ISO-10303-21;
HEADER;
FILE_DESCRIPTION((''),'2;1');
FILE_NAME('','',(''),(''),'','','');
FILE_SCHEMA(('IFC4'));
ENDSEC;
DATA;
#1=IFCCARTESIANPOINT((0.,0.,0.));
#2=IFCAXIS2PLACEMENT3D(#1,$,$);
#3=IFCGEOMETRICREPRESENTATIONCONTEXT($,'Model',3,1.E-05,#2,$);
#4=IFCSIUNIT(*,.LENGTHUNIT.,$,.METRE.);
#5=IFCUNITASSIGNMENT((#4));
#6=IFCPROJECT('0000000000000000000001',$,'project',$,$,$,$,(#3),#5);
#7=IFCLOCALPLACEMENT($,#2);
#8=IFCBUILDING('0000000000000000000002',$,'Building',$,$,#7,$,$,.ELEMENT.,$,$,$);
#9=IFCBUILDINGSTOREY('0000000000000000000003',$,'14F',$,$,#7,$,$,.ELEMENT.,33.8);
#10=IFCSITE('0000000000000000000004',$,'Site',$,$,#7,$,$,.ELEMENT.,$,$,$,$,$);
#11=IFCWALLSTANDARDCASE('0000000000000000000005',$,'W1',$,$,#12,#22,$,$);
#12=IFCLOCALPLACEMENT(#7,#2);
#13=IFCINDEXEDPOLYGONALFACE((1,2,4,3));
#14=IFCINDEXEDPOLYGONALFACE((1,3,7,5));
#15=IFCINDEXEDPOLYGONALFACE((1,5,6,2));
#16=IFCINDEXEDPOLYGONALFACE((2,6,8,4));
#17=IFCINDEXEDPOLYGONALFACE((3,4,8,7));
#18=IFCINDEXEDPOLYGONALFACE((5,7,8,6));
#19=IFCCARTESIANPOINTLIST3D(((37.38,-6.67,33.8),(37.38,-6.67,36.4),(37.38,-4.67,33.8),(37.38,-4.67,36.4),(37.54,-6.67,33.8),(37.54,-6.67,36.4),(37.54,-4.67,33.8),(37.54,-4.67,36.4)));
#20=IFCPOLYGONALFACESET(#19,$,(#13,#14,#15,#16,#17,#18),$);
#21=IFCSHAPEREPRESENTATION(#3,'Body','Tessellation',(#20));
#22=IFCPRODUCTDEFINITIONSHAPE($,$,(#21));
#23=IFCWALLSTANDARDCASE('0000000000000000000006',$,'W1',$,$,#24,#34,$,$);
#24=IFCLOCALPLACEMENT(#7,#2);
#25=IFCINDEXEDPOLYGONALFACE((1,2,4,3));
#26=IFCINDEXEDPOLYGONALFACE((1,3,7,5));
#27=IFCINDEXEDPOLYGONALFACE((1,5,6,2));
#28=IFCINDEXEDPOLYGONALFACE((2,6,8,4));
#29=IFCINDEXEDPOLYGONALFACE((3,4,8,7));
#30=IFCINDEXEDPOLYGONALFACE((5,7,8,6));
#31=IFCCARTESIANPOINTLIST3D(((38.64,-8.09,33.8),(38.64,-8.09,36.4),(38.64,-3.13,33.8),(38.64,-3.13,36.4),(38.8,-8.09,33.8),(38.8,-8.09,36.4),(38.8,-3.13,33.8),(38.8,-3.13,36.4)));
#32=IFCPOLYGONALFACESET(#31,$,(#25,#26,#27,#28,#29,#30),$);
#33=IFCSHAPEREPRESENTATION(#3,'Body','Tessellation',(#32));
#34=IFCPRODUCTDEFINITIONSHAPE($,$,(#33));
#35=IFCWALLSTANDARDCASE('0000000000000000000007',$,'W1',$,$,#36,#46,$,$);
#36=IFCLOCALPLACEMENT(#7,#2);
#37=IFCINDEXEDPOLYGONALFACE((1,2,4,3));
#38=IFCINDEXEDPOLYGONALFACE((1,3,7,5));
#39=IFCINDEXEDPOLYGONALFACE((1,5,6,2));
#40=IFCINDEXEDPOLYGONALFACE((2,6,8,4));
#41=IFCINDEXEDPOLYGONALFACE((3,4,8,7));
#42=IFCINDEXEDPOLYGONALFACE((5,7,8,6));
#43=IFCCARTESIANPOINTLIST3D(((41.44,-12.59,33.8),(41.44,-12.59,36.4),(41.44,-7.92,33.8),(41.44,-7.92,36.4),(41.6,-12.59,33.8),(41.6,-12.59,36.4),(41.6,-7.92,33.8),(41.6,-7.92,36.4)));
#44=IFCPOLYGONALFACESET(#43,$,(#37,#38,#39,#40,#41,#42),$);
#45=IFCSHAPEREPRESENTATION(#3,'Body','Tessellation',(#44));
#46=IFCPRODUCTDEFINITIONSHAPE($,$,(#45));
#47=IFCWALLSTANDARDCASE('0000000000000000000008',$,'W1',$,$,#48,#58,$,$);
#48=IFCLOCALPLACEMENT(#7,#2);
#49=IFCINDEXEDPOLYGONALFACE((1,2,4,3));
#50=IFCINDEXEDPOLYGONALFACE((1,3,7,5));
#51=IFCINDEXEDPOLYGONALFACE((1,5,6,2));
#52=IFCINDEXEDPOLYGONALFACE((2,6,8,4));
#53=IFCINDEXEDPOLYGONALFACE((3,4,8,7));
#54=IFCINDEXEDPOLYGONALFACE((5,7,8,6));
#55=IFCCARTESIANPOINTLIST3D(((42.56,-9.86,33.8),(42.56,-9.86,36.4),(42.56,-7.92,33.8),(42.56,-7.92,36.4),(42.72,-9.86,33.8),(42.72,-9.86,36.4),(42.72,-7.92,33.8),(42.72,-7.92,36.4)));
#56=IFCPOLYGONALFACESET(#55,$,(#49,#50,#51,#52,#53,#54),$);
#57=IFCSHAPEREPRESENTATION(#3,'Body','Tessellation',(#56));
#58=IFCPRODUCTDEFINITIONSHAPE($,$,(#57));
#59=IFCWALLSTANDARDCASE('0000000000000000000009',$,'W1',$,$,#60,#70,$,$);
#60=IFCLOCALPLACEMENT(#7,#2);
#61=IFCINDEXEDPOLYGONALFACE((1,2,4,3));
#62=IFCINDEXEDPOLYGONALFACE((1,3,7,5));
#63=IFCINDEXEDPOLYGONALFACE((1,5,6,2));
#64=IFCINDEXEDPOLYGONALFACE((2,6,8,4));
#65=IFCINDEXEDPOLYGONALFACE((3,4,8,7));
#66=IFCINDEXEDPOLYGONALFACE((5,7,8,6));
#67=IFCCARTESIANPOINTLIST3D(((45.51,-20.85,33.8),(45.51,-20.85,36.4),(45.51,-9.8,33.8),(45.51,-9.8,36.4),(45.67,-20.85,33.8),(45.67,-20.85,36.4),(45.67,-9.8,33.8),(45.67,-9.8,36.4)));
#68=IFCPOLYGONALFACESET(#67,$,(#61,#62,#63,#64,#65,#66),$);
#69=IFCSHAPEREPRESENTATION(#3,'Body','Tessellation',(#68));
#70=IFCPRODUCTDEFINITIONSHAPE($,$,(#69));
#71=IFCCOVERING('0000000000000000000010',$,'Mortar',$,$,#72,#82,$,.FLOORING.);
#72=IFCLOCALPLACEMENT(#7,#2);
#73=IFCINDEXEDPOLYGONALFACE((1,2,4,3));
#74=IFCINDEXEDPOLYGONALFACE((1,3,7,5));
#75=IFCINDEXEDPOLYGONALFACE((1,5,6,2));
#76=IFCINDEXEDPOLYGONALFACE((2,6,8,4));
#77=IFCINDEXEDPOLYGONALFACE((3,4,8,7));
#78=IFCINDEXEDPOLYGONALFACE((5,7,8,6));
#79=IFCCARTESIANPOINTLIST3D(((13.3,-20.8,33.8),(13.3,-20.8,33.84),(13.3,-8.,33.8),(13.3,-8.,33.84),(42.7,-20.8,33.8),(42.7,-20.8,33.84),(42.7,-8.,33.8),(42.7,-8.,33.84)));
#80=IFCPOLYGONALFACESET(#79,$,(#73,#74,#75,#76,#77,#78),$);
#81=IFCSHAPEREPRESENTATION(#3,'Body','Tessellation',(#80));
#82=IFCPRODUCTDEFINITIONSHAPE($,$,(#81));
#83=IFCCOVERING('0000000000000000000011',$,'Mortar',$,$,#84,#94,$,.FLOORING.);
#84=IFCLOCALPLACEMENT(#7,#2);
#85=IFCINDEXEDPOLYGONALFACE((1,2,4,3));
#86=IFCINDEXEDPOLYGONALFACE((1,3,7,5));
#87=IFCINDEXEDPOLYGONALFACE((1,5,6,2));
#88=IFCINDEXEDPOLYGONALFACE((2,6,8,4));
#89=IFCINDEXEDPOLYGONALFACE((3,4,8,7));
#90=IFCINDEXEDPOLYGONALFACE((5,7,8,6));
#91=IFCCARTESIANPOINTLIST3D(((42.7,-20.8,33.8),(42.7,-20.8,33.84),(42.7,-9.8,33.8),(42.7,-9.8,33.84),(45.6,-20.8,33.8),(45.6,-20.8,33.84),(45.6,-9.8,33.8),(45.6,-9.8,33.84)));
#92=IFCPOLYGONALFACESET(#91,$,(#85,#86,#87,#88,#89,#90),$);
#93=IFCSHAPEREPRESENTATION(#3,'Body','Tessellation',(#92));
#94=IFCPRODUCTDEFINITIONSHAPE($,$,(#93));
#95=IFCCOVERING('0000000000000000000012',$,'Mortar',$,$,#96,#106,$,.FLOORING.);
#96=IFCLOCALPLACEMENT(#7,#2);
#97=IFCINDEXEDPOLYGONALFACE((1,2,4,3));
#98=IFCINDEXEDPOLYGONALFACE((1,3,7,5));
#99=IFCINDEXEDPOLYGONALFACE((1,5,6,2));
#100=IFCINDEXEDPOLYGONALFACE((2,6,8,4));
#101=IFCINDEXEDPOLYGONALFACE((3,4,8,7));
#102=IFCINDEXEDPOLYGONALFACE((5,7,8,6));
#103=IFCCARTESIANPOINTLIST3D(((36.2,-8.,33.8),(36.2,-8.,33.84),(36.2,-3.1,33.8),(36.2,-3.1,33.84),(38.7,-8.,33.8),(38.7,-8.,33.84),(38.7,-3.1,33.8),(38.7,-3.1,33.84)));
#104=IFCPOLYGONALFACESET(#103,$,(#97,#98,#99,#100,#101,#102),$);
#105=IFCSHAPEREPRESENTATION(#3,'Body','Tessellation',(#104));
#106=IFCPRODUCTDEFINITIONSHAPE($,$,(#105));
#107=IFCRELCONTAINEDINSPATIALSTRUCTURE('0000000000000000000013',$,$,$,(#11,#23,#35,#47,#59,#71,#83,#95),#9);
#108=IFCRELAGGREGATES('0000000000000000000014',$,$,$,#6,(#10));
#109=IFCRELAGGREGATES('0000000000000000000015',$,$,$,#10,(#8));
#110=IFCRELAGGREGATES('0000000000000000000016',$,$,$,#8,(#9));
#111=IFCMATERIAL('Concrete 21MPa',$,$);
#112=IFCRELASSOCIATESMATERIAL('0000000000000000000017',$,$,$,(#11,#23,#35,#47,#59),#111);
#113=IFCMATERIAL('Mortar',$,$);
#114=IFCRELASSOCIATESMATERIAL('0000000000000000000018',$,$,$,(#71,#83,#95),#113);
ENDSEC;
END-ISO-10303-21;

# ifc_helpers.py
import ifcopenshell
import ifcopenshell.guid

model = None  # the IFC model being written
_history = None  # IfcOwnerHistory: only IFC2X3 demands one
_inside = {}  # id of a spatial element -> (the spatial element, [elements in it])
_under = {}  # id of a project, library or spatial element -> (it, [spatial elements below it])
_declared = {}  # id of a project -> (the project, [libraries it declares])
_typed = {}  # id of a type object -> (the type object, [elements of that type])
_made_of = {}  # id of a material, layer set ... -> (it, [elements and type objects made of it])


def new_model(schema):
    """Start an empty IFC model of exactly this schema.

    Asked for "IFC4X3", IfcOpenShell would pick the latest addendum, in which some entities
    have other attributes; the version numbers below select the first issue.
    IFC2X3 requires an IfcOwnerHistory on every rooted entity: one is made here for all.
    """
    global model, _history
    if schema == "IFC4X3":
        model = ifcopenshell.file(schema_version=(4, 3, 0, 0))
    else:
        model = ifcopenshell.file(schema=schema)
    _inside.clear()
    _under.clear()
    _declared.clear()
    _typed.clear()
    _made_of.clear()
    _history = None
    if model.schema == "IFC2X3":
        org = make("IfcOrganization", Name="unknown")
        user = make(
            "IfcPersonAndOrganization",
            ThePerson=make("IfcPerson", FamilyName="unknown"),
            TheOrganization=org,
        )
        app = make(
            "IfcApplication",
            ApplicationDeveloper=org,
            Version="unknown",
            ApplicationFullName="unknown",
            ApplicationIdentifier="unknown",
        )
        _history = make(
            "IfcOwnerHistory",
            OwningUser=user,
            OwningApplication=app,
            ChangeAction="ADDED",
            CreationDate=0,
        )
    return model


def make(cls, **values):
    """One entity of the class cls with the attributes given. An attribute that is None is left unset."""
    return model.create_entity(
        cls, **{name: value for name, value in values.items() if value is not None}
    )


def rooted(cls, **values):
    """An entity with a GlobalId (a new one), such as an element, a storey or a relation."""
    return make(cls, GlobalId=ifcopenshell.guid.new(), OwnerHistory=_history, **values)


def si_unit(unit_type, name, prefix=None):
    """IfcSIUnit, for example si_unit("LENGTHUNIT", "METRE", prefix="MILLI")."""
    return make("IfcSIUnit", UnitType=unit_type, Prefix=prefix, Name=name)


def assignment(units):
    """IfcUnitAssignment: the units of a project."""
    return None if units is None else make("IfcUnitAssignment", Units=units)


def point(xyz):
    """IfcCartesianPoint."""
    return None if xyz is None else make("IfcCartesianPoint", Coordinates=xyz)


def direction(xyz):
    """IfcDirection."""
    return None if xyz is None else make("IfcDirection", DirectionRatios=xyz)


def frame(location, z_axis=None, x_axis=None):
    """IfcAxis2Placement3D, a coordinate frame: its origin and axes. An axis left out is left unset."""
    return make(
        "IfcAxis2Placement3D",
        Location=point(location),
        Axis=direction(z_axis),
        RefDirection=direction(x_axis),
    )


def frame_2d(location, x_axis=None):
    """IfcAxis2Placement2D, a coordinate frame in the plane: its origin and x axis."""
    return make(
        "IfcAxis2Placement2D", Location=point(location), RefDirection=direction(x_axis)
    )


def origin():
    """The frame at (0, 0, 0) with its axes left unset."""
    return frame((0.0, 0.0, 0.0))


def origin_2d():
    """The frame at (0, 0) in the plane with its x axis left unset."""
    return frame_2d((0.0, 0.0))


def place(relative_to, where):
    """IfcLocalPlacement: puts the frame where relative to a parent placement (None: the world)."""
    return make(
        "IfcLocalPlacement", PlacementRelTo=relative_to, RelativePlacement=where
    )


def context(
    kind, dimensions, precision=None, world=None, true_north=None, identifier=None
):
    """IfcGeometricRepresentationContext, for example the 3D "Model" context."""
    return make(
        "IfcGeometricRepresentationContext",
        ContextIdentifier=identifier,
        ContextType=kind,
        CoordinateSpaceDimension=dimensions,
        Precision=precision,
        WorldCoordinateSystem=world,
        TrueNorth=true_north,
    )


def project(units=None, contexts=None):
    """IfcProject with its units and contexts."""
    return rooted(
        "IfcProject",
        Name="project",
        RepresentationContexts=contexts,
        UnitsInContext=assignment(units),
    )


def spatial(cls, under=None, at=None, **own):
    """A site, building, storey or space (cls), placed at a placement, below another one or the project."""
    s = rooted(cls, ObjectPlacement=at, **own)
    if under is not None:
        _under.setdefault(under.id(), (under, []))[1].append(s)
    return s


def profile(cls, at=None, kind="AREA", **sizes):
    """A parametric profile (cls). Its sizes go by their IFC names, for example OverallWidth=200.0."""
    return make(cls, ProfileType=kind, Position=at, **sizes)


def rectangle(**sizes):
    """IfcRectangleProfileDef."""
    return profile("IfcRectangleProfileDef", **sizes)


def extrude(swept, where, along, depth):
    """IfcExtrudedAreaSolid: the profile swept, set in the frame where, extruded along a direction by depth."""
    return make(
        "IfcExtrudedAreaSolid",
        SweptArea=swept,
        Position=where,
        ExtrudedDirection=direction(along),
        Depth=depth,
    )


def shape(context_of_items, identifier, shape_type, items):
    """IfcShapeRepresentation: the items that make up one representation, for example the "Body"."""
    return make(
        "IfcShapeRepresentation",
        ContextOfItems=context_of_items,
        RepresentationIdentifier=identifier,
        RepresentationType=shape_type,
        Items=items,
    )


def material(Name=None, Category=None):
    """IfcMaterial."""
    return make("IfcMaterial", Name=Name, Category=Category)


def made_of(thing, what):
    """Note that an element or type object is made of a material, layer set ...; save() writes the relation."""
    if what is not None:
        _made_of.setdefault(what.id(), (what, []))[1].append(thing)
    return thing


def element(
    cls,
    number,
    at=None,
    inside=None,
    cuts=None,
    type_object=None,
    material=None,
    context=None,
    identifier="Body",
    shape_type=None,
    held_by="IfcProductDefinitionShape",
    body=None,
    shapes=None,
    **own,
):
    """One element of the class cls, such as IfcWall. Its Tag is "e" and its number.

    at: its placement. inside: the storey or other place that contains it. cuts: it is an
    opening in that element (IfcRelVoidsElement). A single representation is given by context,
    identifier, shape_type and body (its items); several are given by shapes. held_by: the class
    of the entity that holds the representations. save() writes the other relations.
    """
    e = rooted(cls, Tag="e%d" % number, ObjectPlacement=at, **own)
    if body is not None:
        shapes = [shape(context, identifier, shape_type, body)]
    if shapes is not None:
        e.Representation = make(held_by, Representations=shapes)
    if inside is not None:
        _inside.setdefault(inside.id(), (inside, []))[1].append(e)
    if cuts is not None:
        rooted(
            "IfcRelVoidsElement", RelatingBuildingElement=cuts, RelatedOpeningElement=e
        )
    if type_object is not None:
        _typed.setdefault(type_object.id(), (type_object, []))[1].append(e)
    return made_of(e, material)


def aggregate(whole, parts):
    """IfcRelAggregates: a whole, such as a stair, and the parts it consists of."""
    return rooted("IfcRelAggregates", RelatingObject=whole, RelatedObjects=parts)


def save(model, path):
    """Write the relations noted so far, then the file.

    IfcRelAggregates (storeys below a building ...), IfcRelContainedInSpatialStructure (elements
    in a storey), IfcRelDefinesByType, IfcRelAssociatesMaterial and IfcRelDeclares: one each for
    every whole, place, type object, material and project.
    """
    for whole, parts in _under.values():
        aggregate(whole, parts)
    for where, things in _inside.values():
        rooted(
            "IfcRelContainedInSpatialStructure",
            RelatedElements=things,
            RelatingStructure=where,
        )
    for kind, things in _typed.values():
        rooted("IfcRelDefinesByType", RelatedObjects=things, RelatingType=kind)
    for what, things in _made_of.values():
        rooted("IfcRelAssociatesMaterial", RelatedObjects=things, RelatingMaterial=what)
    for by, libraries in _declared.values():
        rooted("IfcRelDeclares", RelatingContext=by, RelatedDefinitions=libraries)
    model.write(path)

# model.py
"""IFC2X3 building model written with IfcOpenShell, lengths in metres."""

from ifc_helpers import new_model, si_unit, frame, origin, origin_2d, place, context, project, spatial, rectangle, extrude, material, element, save


model = new_model("IFC2X3")

# Units and contexts
model_context = context("Model", 3, precision=1e-05, world=origin())
ifc_project = project(units=[si_unit("LENGTHUNIT", "METRE")], contexts=[model_context])

# Site, building, storey
placement = place(None, origin())
site = spatial("IfcSite", under=ifc_project, at=placement, Name="Site", CompositionType="ELEMENT")
building = spatial("IfcBuilding", under=site, at=placement, Name="Building", CompositionType="ELEMENT")
storey = spatial("IfcBuildingStorey", under=building, at=placement, Name="14F", CompositionType="ELEMENT", Elevation=33.8)

# Shared definitions
ifc_material_1 = material(Name="Concrete 21MPa")

# Walls
wall_1_placement = place(None, frame((37.46, -5.67, 33.8)))
element("IfcWallStandardCase", 1, at=wall_1_placement, inside=storey, material=ifc_material_1, Name="W1", context=model_context, shape_type="SweptSolid", body=[
    extrude(rectangle(XDim=0.16, YDim=2.0, at=origin_2d()), origin(), (0.0, 0.0, 1.0), 2.6),
])
wall_2_placement = place(None, frame((38.72, -5.61, 33.8)))
element("IfcWallStandardCase", 2, at=wall_2_placement, inside=storey, material=ifc_material_1, Name="W1", context=model_context, shape_type="SweptSolid", body=[
    extrude(rectangle(XDim=0.16, YDim=4.96, at=origin_2d()), origin(), (0.0, 0.0, 1.0), 2.6),
])
wall_3_placement = place(None, frame((41.52, -10.255, 33.8)))
element("IfcWallStandardCase", 3, at=wall_3_placement, inside=storey, material=ifc_material_1, Name="W1", context=model_context, shape_type="SweptSolid", body=[
    extrude(rectangle(XDim=0.16, YDim=4.67, at=origin_2d()), origin(), (0.0, 0.0, 1.0), 2.6),
])
wall_4_placement = place(None, frame((42.64, -8.89, 33.8)))
element("IfcWallStandardCase", 4, at=wall_4_placement, inside=storey, material=ifc_material_1, Name="W1", context=model_context, shape_type="SweptSolid", body=[
    extrude(rectangle(XDim=0.16, YDim=1.94, at=origin_2d()), origin(), (0.0, 0.0, 1.0), 2.6),
])
wall_5_placement = place(None, frame((45.59, -15.325, 33.8)))
element("IfcWallStandardCase", 5, at=wall_5_placement, inside=storey, material=ifc_material_1, Name="W1", context=model_context, shape_type="SweptSolid", body=[
    extrude(rectangle(XDim=0.16, YDim=11.05, at=origin_2d()), origin(), (0.0, 0.0, 1.0), 2.6),
])

# Coverings
ifc_material_2 = material(Name="Mortar")
covering_1_placement = place(None, frame((28.0, -14.4, 33.8)))
element("IfcCovering", 6, at=covering_1_placement, inside=storey, material=ifc_material_2, Name="Mortar", PredefinedType="FLOORING", context=model_context, shape_type="SweptSolid", body=[
    extrude(rectangle(XDim=29.4, YDim=12.8, at=origin_2d()), origin(), (0.0, 0.0, 1.0), 0.04),
])
covering_2_placement = place(None, frame((44.15, -15.3, 33.8)))
element("IfcCovering", 7, at=covering_2_placement, inside=storey, material=ifc_material_2, Name="Mortar", PredefinedType="FLOORING", context=model_context, shape_type="SweptSolid", body=[
    extrude(rectangle(XDim=2.9, YDim=11.0, at=origin_2d()), origin(), (0.0, 0.0, 1.0), 0.04),
])
covering_3_placement = place(None, frame((37.45, -5.55, 33.8)))
element("IfcCovering", 8, at=covering_3_placement, inside=storey, material=ifc_material_2, Name="Mortar", PredefinedType="FLOORING", context=model_context, shape_type="SweptSolid", body=[
    extrude(rectangle(XDim=2.5, YDim=4.9, at=origin_2d()), origin(), (0.0, 0.0, 1.0), 0.04),
])

save(model, "model.ifc")
